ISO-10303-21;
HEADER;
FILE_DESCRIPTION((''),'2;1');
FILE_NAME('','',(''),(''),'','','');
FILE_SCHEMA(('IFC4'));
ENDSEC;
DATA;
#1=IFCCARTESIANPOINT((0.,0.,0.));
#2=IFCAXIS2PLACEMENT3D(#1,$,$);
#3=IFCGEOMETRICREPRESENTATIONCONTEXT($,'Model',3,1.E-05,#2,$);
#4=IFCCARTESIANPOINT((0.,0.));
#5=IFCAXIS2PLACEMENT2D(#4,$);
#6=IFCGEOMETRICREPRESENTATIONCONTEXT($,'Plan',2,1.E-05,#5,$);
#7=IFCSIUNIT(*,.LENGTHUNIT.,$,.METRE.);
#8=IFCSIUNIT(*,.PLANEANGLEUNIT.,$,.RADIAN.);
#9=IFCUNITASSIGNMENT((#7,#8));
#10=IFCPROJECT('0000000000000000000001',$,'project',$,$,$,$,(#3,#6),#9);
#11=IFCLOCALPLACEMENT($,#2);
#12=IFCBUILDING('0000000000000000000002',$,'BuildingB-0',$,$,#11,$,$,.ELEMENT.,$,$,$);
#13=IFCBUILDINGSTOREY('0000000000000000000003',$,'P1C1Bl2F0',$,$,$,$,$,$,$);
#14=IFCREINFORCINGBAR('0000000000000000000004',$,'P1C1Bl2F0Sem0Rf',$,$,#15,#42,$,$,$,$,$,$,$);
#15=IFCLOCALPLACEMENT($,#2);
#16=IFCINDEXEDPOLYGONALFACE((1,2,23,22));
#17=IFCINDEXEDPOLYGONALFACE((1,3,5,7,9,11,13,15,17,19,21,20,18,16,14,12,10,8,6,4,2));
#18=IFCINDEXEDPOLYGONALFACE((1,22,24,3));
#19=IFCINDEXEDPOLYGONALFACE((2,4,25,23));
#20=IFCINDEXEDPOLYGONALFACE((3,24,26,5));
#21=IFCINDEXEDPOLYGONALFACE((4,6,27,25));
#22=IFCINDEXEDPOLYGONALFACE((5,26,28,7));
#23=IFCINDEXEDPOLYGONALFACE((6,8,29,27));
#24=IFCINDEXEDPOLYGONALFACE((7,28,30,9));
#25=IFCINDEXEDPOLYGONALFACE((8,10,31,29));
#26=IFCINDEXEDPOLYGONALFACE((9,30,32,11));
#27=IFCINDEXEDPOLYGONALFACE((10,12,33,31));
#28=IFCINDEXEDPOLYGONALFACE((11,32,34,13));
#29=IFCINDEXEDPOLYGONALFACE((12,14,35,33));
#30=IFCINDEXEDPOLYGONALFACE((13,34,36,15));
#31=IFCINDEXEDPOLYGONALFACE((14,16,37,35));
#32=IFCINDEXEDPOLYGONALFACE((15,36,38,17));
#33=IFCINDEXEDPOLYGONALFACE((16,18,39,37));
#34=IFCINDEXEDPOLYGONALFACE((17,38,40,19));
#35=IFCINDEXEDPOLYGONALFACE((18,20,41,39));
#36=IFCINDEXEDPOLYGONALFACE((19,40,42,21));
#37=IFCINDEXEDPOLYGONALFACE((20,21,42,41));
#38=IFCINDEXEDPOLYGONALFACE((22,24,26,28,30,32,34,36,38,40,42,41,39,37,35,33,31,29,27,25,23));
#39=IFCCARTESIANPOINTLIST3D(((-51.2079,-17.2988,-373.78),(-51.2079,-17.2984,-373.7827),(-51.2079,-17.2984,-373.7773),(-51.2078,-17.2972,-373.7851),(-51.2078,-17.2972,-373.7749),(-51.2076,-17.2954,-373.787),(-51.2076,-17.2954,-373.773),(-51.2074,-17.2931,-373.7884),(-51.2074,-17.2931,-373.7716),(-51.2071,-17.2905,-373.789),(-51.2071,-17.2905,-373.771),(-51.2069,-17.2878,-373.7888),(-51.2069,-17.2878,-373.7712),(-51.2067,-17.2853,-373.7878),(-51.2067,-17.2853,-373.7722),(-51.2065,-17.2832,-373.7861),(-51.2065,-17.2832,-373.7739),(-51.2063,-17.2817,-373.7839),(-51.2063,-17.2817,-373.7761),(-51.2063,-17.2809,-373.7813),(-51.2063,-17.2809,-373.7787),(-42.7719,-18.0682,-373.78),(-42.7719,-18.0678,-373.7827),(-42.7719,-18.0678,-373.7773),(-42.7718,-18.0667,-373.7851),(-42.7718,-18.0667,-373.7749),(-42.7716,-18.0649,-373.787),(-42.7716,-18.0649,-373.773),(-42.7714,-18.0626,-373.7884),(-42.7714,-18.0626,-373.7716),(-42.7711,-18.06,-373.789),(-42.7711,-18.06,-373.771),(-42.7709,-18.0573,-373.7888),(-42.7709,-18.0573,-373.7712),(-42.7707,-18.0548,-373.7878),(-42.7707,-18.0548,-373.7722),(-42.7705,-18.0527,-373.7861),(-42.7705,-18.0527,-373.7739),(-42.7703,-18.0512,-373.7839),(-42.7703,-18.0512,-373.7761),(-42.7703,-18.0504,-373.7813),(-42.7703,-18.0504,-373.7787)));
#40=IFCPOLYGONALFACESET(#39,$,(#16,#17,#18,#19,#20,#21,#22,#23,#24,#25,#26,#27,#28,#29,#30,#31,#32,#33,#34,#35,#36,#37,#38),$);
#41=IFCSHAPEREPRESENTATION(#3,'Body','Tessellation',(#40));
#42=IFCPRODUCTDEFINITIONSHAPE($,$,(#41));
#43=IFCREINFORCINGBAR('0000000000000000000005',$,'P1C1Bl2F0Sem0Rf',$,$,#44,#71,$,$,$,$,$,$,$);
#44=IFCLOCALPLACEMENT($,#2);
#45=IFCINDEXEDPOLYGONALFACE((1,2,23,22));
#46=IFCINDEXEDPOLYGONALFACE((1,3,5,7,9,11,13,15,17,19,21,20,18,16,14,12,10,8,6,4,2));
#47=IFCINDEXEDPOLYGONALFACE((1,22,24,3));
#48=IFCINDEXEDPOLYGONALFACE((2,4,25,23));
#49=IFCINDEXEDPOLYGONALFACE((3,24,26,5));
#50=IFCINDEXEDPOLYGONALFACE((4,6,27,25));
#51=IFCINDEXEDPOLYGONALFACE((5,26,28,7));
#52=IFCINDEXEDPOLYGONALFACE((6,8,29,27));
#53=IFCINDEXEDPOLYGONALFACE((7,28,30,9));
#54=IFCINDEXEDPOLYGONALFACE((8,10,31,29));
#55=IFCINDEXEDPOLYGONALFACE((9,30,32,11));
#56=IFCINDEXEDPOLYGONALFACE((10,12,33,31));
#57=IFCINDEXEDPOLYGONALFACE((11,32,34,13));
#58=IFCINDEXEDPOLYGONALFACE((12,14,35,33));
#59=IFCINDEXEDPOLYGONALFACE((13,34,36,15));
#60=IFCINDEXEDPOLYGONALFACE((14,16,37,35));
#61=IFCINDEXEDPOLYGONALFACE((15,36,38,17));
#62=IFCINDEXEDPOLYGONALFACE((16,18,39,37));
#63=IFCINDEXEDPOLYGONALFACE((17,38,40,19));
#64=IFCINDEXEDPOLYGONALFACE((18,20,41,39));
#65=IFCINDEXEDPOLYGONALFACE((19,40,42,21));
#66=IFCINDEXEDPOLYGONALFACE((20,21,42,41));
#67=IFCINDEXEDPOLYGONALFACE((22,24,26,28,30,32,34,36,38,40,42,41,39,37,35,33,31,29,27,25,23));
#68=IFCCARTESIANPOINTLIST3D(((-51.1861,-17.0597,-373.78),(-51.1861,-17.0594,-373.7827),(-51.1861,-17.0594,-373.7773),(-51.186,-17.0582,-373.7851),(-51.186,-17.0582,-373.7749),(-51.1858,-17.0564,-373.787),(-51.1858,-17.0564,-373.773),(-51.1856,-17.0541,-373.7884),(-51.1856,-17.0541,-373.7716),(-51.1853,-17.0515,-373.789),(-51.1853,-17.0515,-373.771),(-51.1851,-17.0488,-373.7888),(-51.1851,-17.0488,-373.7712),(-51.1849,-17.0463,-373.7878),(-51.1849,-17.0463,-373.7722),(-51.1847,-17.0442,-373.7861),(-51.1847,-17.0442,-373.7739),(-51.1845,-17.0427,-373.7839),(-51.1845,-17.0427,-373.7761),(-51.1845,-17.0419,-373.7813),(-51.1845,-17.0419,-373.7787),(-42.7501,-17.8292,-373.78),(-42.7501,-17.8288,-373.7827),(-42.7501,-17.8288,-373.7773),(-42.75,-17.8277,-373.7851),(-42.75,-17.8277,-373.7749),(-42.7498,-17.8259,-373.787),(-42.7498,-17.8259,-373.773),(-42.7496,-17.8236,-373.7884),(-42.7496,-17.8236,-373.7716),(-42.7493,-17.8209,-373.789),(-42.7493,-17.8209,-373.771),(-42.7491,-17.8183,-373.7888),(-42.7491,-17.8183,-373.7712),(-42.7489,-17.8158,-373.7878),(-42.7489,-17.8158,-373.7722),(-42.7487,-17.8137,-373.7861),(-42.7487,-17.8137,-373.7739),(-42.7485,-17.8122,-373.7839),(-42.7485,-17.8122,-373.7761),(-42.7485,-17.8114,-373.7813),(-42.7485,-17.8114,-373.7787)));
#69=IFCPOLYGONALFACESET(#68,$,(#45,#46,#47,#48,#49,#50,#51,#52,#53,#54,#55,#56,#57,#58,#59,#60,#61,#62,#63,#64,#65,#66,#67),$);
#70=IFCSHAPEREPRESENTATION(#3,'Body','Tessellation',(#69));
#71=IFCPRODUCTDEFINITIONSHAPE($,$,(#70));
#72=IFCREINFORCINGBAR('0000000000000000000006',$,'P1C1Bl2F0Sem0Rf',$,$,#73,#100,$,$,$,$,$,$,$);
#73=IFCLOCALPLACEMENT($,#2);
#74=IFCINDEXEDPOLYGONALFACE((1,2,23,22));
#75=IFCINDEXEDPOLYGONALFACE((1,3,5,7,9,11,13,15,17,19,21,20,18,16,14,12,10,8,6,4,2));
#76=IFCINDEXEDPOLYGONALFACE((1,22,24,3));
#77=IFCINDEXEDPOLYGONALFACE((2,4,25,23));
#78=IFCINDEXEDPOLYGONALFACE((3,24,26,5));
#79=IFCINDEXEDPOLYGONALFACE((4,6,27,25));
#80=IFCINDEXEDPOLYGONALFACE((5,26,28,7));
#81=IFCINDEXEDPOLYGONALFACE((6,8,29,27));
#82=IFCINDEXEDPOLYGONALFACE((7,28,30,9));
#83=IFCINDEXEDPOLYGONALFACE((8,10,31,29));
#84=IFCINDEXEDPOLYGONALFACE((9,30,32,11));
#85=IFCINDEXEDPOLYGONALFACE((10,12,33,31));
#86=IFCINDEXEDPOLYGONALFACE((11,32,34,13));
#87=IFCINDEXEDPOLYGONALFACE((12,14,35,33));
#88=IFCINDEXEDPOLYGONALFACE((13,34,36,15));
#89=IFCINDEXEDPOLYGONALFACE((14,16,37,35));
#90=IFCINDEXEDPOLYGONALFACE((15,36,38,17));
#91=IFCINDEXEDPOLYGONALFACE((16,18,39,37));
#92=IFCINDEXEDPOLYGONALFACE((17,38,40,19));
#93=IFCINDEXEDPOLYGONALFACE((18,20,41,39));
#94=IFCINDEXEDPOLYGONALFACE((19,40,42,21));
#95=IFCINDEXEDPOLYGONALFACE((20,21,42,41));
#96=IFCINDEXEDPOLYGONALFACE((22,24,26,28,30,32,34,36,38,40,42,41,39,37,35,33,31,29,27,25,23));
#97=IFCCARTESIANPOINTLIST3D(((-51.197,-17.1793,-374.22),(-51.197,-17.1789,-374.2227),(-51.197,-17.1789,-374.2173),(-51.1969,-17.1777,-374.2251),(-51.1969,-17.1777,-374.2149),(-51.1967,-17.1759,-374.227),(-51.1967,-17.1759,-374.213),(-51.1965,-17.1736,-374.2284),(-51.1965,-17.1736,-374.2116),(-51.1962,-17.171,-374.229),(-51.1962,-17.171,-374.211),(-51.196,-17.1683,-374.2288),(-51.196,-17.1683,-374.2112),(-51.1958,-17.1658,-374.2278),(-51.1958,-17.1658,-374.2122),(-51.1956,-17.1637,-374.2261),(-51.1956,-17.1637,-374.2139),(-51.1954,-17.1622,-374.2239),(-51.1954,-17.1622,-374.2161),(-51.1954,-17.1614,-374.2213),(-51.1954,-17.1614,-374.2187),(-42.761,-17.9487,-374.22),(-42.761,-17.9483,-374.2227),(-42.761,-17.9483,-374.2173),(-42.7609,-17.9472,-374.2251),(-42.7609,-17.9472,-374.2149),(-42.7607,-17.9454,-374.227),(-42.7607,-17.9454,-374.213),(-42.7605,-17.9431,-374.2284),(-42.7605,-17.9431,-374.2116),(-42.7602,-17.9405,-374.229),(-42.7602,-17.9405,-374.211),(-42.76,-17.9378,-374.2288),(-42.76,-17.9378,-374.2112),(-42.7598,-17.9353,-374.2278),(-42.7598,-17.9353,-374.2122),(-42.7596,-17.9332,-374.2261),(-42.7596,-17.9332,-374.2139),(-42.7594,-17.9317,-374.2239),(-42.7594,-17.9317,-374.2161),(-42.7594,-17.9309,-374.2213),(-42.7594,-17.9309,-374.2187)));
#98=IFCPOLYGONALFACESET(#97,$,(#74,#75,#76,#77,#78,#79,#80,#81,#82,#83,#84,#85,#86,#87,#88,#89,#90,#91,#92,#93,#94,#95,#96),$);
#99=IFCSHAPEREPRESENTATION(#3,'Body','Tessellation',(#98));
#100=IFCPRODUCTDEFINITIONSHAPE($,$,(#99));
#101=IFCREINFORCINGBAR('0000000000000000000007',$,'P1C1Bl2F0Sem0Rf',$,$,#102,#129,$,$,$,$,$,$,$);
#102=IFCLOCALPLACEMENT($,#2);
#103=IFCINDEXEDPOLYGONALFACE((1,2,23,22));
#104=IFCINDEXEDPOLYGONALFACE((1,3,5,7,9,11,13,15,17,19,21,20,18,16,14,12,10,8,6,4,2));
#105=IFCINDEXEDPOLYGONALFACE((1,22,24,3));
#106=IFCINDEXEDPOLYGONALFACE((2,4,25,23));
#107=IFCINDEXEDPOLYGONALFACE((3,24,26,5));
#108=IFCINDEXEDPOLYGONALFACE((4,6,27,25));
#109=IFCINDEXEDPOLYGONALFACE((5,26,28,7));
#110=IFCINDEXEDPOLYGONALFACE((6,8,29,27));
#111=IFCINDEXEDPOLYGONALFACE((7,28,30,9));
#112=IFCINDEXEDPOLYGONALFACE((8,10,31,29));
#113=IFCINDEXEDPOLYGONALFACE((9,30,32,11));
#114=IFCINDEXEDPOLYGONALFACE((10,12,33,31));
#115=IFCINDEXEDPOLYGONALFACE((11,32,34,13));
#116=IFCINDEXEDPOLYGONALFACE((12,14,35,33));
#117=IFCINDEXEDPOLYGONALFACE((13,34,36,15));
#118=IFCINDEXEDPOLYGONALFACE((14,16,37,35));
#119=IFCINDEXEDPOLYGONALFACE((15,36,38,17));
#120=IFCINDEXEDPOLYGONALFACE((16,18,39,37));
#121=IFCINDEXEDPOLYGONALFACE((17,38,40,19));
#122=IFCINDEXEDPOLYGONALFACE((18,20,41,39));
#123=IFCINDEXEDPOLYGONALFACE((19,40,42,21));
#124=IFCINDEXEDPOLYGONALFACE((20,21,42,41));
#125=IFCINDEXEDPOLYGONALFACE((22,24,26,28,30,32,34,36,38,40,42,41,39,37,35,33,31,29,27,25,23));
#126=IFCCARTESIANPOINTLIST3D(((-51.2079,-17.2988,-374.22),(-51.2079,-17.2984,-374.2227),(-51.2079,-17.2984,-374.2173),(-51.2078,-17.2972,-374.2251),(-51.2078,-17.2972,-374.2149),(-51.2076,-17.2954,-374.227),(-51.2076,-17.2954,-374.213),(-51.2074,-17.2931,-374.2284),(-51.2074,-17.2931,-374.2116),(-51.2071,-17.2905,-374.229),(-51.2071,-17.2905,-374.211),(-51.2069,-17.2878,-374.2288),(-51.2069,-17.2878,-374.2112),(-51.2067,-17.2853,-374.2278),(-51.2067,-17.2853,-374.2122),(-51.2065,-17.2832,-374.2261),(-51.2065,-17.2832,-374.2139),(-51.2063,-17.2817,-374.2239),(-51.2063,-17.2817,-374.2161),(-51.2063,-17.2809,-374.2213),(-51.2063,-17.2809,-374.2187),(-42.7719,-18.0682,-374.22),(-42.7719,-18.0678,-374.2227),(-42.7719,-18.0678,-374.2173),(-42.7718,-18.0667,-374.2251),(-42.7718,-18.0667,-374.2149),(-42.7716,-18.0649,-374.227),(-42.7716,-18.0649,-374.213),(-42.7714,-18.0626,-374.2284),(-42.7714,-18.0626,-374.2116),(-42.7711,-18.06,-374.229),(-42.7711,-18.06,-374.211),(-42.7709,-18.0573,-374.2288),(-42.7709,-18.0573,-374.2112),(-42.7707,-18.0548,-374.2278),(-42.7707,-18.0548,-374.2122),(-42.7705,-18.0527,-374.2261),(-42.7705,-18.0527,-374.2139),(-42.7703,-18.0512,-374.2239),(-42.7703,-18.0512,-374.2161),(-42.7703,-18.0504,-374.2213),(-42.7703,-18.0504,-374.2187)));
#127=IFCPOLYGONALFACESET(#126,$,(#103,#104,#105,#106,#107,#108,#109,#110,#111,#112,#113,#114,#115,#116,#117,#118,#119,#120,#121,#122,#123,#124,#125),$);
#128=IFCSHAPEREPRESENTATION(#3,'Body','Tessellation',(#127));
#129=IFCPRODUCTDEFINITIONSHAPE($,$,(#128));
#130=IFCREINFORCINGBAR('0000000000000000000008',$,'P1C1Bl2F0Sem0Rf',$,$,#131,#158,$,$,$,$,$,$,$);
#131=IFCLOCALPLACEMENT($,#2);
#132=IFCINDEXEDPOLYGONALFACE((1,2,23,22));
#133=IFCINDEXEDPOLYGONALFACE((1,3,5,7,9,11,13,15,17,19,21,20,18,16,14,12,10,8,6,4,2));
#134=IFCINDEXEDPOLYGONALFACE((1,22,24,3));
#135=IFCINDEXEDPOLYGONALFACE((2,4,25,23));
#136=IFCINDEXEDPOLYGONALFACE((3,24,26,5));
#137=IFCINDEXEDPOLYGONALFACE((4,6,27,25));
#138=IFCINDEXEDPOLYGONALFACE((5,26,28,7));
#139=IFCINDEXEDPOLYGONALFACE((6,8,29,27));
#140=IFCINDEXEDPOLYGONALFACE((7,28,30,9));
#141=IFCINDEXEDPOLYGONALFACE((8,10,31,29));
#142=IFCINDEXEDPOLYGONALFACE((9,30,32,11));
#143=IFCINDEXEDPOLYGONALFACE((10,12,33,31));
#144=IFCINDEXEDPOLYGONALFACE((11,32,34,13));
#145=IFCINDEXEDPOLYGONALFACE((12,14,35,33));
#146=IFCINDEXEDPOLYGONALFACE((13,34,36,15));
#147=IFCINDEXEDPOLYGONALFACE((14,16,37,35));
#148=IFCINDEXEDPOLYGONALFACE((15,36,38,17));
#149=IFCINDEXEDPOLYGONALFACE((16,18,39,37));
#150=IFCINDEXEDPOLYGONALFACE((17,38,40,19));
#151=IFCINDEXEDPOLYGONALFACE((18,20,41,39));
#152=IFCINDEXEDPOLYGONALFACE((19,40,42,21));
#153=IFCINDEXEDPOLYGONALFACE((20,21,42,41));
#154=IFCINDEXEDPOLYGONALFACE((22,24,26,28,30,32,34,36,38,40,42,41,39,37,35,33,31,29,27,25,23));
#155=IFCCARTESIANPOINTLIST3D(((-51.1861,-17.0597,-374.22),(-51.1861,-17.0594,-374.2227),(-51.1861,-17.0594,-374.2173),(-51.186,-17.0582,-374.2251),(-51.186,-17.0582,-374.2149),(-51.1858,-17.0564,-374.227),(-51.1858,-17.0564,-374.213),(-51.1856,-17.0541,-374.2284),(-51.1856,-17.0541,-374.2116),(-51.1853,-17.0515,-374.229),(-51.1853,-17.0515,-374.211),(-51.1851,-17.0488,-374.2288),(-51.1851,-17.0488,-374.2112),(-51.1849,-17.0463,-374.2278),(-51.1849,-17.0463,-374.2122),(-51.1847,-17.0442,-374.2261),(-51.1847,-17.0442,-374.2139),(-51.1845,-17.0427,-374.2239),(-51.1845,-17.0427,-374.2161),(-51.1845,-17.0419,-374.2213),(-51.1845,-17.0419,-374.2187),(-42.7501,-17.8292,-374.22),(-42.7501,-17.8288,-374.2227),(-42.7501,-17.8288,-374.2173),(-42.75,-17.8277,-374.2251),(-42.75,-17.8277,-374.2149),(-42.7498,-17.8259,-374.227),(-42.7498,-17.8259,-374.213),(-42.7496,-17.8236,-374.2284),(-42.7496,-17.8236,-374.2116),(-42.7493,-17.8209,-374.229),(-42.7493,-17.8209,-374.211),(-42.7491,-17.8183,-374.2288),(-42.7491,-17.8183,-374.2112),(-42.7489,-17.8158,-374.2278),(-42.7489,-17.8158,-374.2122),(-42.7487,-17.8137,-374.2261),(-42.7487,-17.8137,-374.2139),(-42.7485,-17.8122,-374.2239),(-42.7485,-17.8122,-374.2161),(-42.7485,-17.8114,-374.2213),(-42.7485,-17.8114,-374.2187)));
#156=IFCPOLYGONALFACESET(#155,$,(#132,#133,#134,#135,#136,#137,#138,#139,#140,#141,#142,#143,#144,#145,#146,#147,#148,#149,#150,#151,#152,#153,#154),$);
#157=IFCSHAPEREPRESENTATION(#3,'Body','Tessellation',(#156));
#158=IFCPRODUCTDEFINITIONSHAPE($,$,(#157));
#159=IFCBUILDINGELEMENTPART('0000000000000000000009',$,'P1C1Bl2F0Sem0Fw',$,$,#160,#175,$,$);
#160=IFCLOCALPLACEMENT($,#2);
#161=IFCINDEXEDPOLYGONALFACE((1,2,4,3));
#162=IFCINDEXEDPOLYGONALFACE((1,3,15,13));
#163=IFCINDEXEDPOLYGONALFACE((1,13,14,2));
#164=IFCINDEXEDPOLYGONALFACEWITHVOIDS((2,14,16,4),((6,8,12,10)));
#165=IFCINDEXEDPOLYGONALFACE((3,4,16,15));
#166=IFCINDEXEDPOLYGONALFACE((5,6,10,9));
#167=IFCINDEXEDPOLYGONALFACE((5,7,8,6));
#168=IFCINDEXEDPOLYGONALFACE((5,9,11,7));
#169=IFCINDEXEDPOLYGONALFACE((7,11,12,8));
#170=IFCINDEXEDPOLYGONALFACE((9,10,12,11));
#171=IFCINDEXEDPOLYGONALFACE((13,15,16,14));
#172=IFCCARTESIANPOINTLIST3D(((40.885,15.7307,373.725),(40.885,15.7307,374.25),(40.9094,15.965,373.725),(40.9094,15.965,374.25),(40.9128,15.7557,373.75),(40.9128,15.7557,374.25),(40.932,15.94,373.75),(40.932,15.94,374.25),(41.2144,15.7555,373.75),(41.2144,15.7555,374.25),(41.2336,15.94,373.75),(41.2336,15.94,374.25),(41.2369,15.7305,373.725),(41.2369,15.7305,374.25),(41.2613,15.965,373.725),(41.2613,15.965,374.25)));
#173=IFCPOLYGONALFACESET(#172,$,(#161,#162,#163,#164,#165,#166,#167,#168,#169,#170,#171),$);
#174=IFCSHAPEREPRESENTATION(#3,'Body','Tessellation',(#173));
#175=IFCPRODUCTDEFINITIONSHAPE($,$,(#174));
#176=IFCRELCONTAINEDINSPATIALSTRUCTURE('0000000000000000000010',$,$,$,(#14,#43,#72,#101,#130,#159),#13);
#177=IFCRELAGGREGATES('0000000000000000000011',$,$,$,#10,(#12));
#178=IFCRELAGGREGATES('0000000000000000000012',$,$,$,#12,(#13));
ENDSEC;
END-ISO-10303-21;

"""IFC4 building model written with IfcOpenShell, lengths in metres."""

from ifc_helpers import new_model, entity, si_unit, origin, origin_2d, place, context, project, spatial, polyline, outline, extrude, element, save


model = new_model("IFC4")

# Units and contexts
model_context = context("Model", 3, precision=1e-05, world=origin())
plan_context = context("Plan", 2, precision=1e-05, world=origin_2d())
ifc_project = project(units=[si_unit("LENGTHUNIT", "METRE"), si_unit("PLANEANGLEUNIT", "RADIAN")], contexts=[model_context, plan_context])

# Building, storey
building_placement = place(None, origin())
building = spatial("IfcBuilding", under=ifc_project, at=building_placement, Name="BuildingB-0", CompositionType="ELEMENT")
storey = spatial("IfcBuildingStorey", under=building, Name="P1C1Bl2F0")

# Reinforcing bars
element("IfcReinforcingBar", 1, inside=storey, Name="P1C1Bl2F0Sem0Rf", context=model_context, shape_type="SweptSolid", body=[
    entity("IfcSurfaceCurveSweptAreaSolid", entity("IfcCircleProfileDef", "AREA", None, None, 0.009), None, entity("IfcPolyline", [entity("IfcCartesianPoint", [51.2071, 17.2898, 373.78]), entity("IfcCartesianPoint", [42.7711, 18.0593, 373.78])]), None, None, entity("IfcPlane", entity("IfcAxis2Placement3D", entity("IfcCartesianPoint", [51.2071, 17.2898, 373.78]), entity("IfcDirection", [0.0, 0.0, 1.0]), entity("IfcDirection", [1.0, 0.0, 0.0])))),
])
element("IfcReinforcingBar", 2, inside=storey, Name="P1C1Bl2F0Sem0Rf", context=model_context, shape_type="SweptSolid", body=[
    entity("IfcSurfaceCurveSweptAreaSolid", entity("IfcCircleProfileDef", "AREA", None, None, 0.009), None, entity("IfcPolyline", [entity("IfcCartesianPoint", [51.1853, 17.0508, 373.78]), entity("IfcCartesianPoint", [42.7493, 17.8203, 373.78])]), None, None, entity("IfcPlane", entity("IfcAxis2Placement3D", entity("IfcCartesianPoint", [51.1853, 17.0508, 373.78]), entity("IfcDirection", [0.0, 0.0, 1.0]), entity("IfcDirection", [1.0, 0.0, 0.0])))),
])
element("IfcReinforcingBar", 3, inside=storey, Name="P1C1Bl2F0Sem0Rf", context=model_context, shape_type="SweptSolid", body=[
    entity("IfcSurfaceCurveSweptAreaSolid", entity("IfcCircleProfileDef", "AREA", None, None, 0.009), None, entity("IfcPolyline", [entity("IfcCartesianPoint", [51.1962, 17.1703, 374.22]), entity("IfcCartesianPoint", [42.7602, 17.9398, 374.22])]), None, None, entity("IfcPlane", entity("IfcAxis2Placement3D", entity("IfcCartesianPoint", [51.1962, 17.1703, 374.22]), entity("IfcDirection", [0.0, 0.0, 1.0]), entity("IfcDirection", [1.0, 0.0, 0.0])))),
])
element("IfcReinforcingBar", 4, inside=storey, Name="P1C1Bl2F0Sem0Rf", context=model_context, shape_type="SweptSolid", body=[
    entity("IfcSurfaceCurveSweptAreaSolid", entity("IfcCircleProfileDef", "AREA", None, None, 0.009), None, entity("IfcPolyline", [entity("IfcCartesianPoint", [51.2071, 17.2898, 374.22]), entity("IfcCartesianPoint", [42.7711, 18.0593, 374.22])]), None, None, entity("IfcPlane", entity("IfcAxis2Placement3D", entity("IfcCartesianPoint", [51.2071, 17.2898, 374.22]), entity("IfcDirection", [0.0, 0.0, 1.0]), entity("IfcDirection", [1.0, 0.0, 0.0])))),
])
element("IfcReinforcingBar", 5, inside=storey, Name="P1C1Bl2F0Sem0Rf", context=model_context, shape_type="SweptSolid", body=[
    entity("IfcSurfaceCurveSweptAreaSolid", entity("IfcCircleProfileDef", "AREA", None, None, 0.009), None, entity("IfcPolyline", [entity("IfcCartesianPoint", [51.1853, 17.0508, 374.22]), entity("IfcCartesianPoint", [42.7493, 17.8203, 374.22])]), None, None, entity("IfcPlane", entity("IfcAxis2Placement3D", entity("IfcCartesianPoint", [51.1853, 17.0508, 374.22]), entity("IfcDirection", [0.0, 0.0, 1.0]), entity("IfcDirection", [1.0, 0.0, 0.0])))),
])

# Building element part, opening
building_element_part_1 = element("IfcBuildingElementPart", 6, inside=storey, Name="P1C1Bl2F0Sem0Fw", context=model_context, shape_type="SweptSolid", body=[
    extrude(outline(polyline([(40.885, 15.7307, 373.725), (40.9094, 15.965, 373.725), (41.2613, 15.965, 373.725), (41.2369, 15.7305, 373.725), (40.885, 15.7307, 373.725)])), None, (0.0, 0.0, 1.0), 0.525),
])
element("IfcOpeningElement", 7, inside=storey, cuts=building_element_part_1, context=model_context, shape_type="SweptSolid", body=[
    extrude(outline(polyline([(40.9128, 15.7557, 373.75), (40.932, 15.94, 373.75), (41.2336, 15.94, 373.75), (41.2144, 15.7555, 373.75), (40.9128, 15.7557, 373.75)])), None, (0.0, 0.0, 1.0), 0.5),
])

save(model, "model.ifc")
